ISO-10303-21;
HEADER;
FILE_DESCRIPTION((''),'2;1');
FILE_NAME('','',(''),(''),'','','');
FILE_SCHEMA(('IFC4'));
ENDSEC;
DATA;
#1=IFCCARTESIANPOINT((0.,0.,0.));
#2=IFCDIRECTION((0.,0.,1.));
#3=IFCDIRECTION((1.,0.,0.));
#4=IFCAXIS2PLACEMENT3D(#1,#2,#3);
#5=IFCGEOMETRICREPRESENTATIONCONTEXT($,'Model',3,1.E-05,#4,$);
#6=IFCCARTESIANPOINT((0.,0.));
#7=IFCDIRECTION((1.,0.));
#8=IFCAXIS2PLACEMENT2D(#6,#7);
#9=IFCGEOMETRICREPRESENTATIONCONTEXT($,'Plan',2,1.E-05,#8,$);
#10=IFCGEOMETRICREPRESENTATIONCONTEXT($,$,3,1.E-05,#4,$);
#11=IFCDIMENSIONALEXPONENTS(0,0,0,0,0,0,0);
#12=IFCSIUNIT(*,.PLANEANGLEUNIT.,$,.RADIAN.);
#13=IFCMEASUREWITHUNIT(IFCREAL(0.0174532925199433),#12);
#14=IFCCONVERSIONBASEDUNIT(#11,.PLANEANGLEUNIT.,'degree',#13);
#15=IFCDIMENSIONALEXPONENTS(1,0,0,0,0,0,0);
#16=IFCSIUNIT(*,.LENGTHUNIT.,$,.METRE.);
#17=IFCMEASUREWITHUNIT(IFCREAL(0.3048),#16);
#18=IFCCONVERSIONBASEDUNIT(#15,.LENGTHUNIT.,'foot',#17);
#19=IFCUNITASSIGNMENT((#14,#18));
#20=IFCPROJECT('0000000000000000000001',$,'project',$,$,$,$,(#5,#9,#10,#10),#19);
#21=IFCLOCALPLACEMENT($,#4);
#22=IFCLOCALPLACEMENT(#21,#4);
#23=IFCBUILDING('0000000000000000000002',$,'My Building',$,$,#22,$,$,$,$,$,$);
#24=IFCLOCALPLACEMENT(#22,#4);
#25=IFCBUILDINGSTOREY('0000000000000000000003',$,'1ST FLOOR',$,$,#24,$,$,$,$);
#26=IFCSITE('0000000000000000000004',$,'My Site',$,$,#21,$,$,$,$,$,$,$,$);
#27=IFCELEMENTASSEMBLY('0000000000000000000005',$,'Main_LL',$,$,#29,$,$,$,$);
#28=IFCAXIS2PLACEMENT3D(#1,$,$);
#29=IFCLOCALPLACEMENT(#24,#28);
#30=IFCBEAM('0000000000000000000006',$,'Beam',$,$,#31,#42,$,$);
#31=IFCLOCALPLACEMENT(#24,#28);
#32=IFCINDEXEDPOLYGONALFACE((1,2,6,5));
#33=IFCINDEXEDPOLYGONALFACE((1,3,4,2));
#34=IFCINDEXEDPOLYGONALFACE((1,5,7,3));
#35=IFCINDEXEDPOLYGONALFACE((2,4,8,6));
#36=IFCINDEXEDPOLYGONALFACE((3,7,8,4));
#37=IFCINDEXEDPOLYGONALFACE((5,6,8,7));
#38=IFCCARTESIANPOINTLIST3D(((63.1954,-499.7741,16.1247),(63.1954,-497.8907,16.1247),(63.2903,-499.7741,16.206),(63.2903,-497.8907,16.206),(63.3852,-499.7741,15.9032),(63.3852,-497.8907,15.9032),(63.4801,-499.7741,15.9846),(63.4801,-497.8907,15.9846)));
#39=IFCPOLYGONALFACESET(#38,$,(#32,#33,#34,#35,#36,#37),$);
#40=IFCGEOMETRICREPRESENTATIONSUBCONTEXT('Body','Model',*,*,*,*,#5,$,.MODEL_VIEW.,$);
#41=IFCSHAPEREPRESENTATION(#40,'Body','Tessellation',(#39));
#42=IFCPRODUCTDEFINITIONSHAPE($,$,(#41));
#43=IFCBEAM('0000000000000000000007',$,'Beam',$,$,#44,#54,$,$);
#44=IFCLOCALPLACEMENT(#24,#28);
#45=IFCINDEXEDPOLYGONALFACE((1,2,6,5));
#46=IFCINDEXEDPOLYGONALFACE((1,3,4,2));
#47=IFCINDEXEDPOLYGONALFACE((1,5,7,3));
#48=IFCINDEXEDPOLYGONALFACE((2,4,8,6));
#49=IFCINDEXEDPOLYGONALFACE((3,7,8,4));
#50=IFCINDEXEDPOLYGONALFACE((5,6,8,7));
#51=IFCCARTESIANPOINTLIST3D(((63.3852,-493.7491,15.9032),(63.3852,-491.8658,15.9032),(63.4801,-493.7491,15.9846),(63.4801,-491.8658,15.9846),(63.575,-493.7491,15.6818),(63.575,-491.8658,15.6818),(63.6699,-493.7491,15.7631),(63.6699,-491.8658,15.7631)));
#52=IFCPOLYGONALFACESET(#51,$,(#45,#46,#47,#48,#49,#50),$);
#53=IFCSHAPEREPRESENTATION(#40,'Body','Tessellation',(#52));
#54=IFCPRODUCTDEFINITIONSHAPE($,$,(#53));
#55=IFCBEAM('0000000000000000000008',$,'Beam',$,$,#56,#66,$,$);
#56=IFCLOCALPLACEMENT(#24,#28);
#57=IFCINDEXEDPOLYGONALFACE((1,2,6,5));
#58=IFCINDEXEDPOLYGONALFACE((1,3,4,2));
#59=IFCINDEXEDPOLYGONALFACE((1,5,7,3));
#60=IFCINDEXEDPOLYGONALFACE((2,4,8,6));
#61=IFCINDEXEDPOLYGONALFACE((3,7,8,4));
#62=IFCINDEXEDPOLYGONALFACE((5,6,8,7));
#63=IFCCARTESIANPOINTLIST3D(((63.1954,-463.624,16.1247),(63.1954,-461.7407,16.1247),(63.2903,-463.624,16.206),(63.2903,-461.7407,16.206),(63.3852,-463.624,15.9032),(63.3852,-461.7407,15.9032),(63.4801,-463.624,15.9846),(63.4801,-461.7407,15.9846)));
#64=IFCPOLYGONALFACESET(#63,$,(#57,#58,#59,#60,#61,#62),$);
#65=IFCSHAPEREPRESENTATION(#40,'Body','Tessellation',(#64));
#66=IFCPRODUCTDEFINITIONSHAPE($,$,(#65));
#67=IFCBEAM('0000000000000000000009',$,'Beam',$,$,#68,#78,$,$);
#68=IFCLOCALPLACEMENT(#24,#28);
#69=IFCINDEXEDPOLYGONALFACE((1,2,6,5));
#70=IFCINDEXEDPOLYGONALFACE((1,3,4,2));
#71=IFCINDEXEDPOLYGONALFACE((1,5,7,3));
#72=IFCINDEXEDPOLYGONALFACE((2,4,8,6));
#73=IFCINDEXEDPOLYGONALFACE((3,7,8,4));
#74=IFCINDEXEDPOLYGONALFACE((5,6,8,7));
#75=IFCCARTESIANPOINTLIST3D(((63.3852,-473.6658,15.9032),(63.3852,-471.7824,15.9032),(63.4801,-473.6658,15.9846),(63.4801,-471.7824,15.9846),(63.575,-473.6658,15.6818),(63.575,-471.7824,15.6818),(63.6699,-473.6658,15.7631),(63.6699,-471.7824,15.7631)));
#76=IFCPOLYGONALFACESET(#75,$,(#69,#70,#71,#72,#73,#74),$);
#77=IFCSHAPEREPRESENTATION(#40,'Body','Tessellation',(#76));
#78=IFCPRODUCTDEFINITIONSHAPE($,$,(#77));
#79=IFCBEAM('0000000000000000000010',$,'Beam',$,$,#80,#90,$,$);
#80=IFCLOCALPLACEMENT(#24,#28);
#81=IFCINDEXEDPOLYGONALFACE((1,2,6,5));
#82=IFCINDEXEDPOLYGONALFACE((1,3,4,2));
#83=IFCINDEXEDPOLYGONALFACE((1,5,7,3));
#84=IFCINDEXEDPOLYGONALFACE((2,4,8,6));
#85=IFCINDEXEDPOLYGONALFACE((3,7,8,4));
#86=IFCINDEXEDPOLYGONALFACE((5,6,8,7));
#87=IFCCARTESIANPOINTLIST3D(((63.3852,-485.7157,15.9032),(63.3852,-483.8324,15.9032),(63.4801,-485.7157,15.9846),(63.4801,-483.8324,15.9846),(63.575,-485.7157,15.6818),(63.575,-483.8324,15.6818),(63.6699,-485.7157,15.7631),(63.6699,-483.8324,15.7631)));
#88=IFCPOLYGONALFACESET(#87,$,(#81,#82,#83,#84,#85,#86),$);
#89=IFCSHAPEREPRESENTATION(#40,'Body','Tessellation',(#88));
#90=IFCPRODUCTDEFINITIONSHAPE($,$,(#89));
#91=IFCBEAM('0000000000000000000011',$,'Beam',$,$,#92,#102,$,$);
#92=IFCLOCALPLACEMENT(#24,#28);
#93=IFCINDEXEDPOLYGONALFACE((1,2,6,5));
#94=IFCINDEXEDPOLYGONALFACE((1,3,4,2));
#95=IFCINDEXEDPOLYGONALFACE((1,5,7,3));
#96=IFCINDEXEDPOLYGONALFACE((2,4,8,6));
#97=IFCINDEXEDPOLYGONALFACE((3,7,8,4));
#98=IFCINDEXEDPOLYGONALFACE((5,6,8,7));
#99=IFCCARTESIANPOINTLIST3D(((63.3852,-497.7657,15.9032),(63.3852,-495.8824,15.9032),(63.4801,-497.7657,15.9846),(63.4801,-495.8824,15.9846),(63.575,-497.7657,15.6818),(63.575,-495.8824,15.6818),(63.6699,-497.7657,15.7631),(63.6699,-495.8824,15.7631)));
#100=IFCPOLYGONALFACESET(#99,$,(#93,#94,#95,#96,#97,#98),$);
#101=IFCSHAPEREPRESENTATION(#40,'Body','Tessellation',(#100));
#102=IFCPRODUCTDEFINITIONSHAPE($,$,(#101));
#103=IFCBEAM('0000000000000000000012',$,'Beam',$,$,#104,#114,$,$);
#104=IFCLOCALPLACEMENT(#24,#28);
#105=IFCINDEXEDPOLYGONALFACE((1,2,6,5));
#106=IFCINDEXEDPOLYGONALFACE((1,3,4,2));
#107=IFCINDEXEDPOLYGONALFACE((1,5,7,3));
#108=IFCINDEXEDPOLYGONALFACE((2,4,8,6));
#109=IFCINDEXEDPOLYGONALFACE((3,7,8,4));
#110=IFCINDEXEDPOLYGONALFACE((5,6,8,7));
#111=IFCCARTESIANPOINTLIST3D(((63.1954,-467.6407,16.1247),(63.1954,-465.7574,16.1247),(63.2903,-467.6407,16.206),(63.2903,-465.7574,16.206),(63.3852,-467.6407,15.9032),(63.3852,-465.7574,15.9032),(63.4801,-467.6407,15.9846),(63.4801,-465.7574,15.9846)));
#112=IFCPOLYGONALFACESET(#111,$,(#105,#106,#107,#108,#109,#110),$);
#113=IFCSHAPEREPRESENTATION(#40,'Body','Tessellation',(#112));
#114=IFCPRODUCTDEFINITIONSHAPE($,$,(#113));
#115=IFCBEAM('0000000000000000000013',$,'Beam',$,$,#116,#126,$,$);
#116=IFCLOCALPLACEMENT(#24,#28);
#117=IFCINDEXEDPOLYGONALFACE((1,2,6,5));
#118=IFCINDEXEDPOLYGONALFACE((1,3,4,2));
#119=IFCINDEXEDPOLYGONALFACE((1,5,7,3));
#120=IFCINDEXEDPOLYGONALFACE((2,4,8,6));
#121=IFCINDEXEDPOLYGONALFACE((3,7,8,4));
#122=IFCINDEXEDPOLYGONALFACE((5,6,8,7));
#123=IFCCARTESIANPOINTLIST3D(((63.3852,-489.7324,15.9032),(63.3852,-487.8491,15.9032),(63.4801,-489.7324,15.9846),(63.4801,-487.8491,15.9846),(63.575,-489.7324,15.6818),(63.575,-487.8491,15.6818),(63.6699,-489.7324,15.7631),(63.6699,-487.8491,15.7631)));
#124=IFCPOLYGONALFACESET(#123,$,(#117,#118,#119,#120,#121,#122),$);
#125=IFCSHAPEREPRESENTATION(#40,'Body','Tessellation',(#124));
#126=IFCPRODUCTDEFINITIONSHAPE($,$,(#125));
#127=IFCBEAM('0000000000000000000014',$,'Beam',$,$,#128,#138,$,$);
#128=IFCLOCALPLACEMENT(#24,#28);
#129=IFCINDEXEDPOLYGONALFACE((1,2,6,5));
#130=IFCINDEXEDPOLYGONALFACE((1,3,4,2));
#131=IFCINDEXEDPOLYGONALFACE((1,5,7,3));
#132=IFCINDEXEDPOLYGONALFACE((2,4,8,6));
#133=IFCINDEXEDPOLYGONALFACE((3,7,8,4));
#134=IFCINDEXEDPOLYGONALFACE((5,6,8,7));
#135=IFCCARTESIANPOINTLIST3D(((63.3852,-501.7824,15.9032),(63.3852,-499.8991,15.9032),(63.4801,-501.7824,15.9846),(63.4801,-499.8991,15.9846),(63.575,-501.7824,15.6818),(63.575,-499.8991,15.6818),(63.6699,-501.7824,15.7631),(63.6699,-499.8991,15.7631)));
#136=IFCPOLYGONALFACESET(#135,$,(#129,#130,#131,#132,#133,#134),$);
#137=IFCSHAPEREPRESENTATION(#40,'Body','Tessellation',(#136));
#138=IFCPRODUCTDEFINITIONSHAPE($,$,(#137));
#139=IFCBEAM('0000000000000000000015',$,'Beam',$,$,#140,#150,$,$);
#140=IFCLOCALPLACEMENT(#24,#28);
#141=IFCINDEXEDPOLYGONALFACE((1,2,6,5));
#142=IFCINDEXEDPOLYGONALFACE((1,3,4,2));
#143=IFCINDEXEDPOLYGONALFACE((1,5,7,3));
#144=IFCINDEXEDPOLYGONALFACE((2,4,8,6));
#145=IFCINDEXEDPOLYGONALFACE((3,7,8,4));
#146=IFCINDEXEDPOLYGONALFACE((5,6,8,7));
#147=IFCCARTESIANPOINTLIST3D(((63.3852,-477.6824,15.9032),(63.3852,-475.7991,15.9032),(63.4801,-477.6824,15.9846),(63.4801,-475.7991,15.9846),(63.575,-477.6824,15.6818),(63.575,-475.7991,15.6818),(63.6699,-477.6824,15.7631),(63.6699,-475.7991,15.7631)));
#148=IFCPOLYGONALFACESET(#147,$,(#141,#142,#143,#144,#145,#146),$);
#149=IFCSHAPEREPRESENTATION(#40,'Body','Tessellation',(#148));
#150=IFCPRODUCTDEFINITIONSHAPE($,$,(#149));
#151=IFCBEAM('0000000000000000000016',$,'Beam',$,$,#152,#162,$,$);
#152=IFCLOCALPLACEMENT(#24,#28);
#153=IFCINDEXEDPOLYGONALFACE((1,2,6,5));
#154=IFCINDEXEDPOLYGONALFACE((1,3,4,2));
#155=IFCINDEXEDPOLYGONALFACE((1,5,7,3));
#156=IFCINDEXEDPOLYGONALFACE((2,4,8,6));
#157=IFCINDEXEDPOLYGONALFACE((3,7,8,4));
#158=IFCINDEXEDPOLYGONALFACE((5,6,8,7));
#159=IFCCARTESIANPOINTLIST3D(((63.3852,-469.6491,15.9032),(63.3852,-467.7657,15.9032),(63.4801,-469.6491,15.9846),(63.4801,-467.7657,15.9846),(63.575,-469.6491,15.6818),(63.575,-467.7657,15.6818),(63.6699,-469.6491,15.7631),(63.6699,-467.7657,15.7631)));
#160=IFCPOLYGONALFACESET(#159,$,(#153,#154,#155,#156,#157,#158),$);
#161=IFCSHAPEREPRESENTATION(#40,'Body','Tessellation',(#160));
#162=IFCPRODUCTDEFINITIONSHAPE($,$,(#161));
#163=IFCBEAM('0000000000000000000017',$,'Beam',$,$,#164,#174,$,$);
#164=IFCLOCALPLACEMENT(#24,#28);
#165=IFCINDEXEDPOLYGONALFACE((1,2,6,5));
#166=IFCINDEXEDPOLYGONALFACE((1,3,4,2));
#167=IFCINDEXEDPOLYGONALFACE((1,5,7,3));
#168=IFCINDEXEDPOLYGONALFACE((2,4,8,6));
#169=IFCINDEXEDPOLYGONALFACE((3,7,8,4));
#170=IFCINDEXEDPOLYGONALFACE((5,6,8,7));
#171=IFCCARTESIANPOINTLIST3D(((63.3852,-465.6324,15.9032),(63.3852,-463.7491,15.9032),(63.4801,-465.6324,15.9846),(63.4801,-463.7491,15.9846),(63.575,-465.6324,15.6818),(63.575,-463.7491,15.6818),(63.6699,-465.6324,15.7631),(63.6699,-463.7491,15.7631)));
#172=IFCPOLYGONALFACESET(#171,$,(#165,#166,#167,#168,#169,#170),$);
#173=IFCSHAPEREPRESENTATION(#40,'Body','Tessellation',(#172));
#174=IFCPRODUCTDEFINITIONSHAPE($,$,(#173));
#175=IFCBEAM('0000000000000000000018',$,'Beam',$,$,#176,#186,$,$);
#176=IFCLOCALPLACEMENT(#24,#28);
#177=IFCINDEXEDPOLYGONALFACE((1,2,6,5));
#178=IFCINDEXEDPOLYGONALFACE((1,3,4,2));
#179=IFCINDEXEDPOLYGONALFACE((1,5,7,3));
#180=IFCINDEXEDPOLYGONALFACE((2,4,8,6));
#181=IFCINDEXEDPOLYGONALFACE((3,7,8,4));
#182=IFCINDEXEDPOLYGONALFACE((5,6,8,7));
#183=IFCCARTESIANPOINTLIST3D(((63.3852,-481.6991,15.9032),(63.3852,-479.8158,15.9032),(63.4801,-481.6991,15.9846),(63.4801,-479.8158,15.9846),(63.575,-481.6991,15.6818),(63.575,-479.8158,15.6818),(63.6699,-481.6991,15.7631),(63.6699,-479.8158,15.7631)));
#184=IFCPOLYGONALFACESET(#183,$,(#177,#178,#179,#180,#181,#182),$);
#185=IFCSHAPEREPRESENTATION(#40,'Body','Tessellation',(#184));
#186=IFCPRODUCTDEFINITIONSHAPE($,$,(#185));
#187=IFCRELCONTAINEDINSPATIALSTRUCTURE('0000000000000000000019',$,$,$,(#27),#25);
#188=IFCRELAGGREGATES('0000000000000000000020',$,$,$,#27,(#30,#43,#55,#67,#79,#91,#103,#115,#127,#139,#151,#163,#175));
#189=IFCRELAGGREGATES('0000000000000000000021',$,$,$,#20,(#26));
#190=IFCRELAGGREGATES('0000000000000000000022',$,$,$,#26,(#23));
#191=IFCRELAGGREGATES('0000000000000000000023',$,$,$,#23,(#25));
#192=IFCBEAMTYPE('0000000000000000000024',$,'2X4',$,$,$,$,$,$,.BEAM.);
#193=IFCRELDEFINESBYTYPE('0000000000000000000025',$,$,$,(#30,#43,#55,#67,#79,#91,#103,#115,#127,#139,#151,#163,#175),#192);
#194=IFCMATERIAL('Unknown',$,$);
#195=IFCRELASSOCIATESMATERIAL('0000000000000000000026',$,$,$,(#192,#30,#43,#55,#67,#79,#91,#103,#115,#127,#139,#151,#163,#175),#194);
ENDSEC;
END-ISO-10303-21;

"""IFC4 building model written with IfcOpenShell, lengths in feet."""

from ifc_helpers import new_model, entity, si_unit, converted_unit, frame, origin_with_axes, origin_2d_with_axis, place, context, subcontext, project, spatial, rectangle, extrude, material, material_profile, profile_set, profile_usage, type_object, element, aggregate, save


model = new_model("IFC4")

# Units and contexts
model_context = context("Model", 3, precision=1e-05, world=origin_with_axes())
plan_context = context("Plan", 2, precision=1e-05, world=origin_2d_with_axis())
context_of_model = context(None, 3, precision=1e-05, world=origin_with_axes())
body_context = subcontext(model_context, "Body", "Model", "MODEL_VIEW")
ifc_project = project(units=[converted_unit("PLANEANGLEUNIT", "degree", entity("IfcReal", 0.0174532925199433), si_unit("PLANEANGLEUNIT", "RADIAN"), dimensions=[0, 0, 0, 0, 0, 0, 0]), converted_unit("LENGTHUNIT", "foot", entity("IfcReal", 0.3048), si_unit("LENGTHUNIT", "METRE"), dimensions=[1, 0, 0, 0, 0, 0, 0])], contexts=[model_context, plan_context, context_of_model, context_of_model])

# Site, building, storey
site_placement = place(None, origin_with_axes())
site = spatial("IfcSite", under=ifc_project, at=site_placement, Name="My Site")
building_placement = place(site_placement, origin_with_axes())
building = spatial("IfcBuilding", under=site, at=building_placement, Name="My Building")
storey_placement = place(building_placement, origin_with_axes())
storey = spatial("IfcBuildingStorey", under=building, at=storey_placement, Name="1ST FLOOR")

# Element assembly, beams
assembly_placement = place(storey_placement, origin_with_axes())
assembly = element("IfcElementAssembly", 1, at=assembly_placement, inside=storey, Name="Main_LL")
ifc_material_1 = material(Name="Unknown")
ifc_material_profile_1 = material_profile(ifc_material_1, rectangle(XDim=0.125, YDim=0.2917))
ifc_profile_set_1 = profile_set([ifc_material_profile_1])
ifc_profile_usage_1 = profile_usage(ifc_profile_set_1, cardinal=5)
beam_type_1 = type_object("IfcBeamType", Name="2X4", PredefinedType="BEAM", material=ifc_profile_set_1)
beam_1_placement = place(assembly_placement, frame((63.3378, -497.8907, 16.0546), z_axis=(0.0, -1.0, 0.0), x_axis=(-0.759271, 0.0, -0.650774)))
beam_1 = element("IfcBeam", 2, at=beam_1_placement, type_object=beam_type_1, material=ifc_profile_usage_1, Name="Beam", context=body_context, shape_type="SweptSolid", body=[
    extrude(rectangle(XDim=0.125, YDim=0.2917), origin_with_axes(), (0.0, 0.0, 1.0), 1.8833),
])
ifc_profile_usage_2 = profile_usage(ifc_profile_set_1, cardinal=5)
beam_2_placement = place(assembly_placement, frame((63.5276, -491.8658, 15.8332), z_axis=(0.0, -1.0, 0.0), x_axis=(-0.759271, 0.0, -0.650774)))
beam_2 = element("IfcBeam", 3, at=beam_2_placement, type_object=beam_type_1, material=ifc_profile_usage_2, Name="Beam", context=body_context, shape_type="SweptSolid", body=[
    extrude(rectangle(XDim=0.125, YDim=0.2917), origin_with_axes(), (0.0, 0.0, 1.0), 1.8833),
])
ifc_profile_usage_3 = profile_usage(ifc_profile_set_1, cardinal=5)
beam_3_placement = place(assembly_placement, frame((63.3378, -461.7407, 16.0546), z_axis=(0.0, -1.0, 0.0), x_axis=(-0.759271, 0.0, -0.650774)))
beam_3 = element("IfcBeam", 4, at=beam_3_placement, type_object=beam_type_1, material=ifc_profile_usage_3, Name="Beam", context=body_context, shape_type="SweptSolid", body=[
    extrude(rectangle(XDim=0.125, YDim=0.2917), origin_with_axes(), (0.0, 0.0, 1.0), 1.8833),
])
ifc_profile_usage_4 = profile_usage(ifc_profile_set_1, cardinal=5)
beam_4_placement = place(assembly_placement, frame((63.5276, -471.7824, 15.8332), z_axis=(0.0, -1.0, 0.0), x_axis=(-0.759271, 0.0, -0.650774)))
beam_4 = element("IfcBeam", 5, at=beam_4_placement, type_object=beam_type_1, material=ifc_profile_usage_4, Name="Beam", context=body_context, shape_type="SweptSolid", body=[
    extrude(rectangle(XDim=0.125, YDim=0.2917), origin_with_axes(), (0.0, 0.0, 1.0), 1.8833),
])
ifc_profile_usage_5 = profile_usage(ifc_profile_set_1, cardinal=5)
beam_5_placement = place(assembly_placement, frame((63.5276, -483.8324, 15.8332), z_axis=(0.0, -1.0, 0.0), x_axis=(-0.759271, 0.0, -0.650774)))
beam_5 = element("IfcBeam", 6, at=beam_5_placement, type_object=beam_type_1, material=ifc_profile_usage_5, Name="Beam", context=body_context, shape_type="SweptSolid", body=[
    extrude(rectangle(XDim=0.125, YDim=0.2917), origin_with_axes(), (0.0, 0.0, 1.0), 1.8833),
])
ifc_profile_usage_6 = profile_usage(ifc_profile_set_1, cardinal=5)
beam_6_placement = place(assembly_placement, frame((63.5276, -495.8824, 15.8332), z_axis=(0.0, -1.0, 0.0), x_axis=(-0.759271, 0.0, -0.650774)))
beam_6 = element("IfcBeam", 7, at=beam_6_placement, type_object=beam_type_1, material=ifc_profile_usage_6, Name="Beam", context=body_context, shape_type="SweptSolid", body=[
    extrude(rectangle(XDim=0.125, YDim=0.2917), origin_with_axes(), (0.0, 0.0, 1.0), 1.8833),
])
ifc_profile_usage_7 = profile_usage(ifc_profile_set_1, cardinal=5)
beam_7_placement = place(assembly_placement, frame((63.3378, -465.7574, 16.0546), z_axis=(0.0, -1.0, 0.0), x_axis=(-0.759271, 0.0, -0.650774)))
beam_7 = element("IfcBeam", 8, at=beam_7_placement, type_object=beam_type_1, material=ifc_profile_usage_7, Name="Beam", context=body_context, shape_type="SweptSolid", body=[
    extrude(rectangle(XDim=0.125, YDim=0.2917), origin_with_axes(), (0.0, 0.0, 1.0), 1.8833),
])
ifc_profile_usage_8 = profile_usage(ifc_profile_set_1, cardinal=5)
beam_8_placement = place(assembly_placement, frame((63.5276, -487.8491, 15.8332), z_axis=(0.0, -1.0, 0.0), x_axis=(-0.759271, 0.0, -0.650774)))
beam_8 = element("IfcBeam", 9, at=beam_8_placement, type_object=beam_type_1, material=ifc_profile_usage_8, Name="Beam", context=body_context, shape_type="SweptSolid", body=[
    extrude(rectangle(XDim=0.125, YDim=0.2917), origin_with_axes(), (0.0, 0.0, 1.0), 1.8833),
])
ifc_profile_usage_9 = profile_usage(ifc_profile_set_1, cardinal=5)
beam_9_placement = place(assembly_placement, frame((63.5276, -499.8991, 15.8332), z_axis=(0.0, -1.0, 0.0), x_axis=(-0.759271, 0.0, -0.650774)))
beam_9 = element("IfcBeam", 10, at=beam_9_placement, type_object=beam_type_1, material=ifc_profile_usage_9, Name="Beam", context=body_context, shape_type="SweptSolid", body=[
    extrude(rectangle(XDim=0.125, YDim=0.2917), origin_with_axes(), (0.0, 0.0, 1.0), 1.8833),
])
ifc_profile_usage_10 = profile_usage(ifc_profile_set_1, cardinal=5)
beam_10_placement = place(assembly_placement, frame((63.5276, -475.7991, 15.8332), z_axis=(0.0, -1.0, 0.0), x_axis=(-0.759271, 0.0, -0.650774)))
beam_10 = element("IfcBeam", 11, at=beam_10_placement, type_object=beam_type_1, material=ifc_profile_usage_10, Name="Beam", context=body_context, shape_type="SweptSolid", body=[
    extrude(rectangle(XDim=0.125, YDim=0.2917), origin_with_axes(), (0.0, 0.0, 1.0), 1.8833),
])
ifc_profile_usage_11 = profile_usage(ifc_profile_set_1, cardinal=5)
beam_11_placement = place(assembly_placement, frame((63.5276, -467.7657, 15.8332), z_axis=(0.0, -1.0, 0.0), x_axis=(-0.759271, 0.0, -0.650774)))
beam_11 = element("IfcBeam", 12, at=beam_11_placement, type_object=beam_type_1, material=ifc_profile_usage_11, Name="Beam", context=body_context, shape_type="SweptSolid", body=[
    extrude(rectangle(XDim=0.125, YDim=0.2917), origin_with_axes(), (0.0, 0.0, 1.0), 1.8833),
])
ifc_profile_usage_12 = profile_usage(ifc_profile_set_1, cardinal=5)
beam_12_placement = place(assembly_placement, frame((63.5276, -463.7491, 15.8332), z_axis=(0.0, -1.0, 0.0), x_axis=(-0.759271, 0.0, -0.650774)))
beam_12 = element("IfcBeam", 13, at=beam_12_placement, type_object=beam_type_1, material=ifc_profile_usage_12, Name="Beam", context=body_context, shape_type="SweptSolid", body=[
    extrude(rectangle(XDim=0.125, YDim=0.2917), origin_with_axes(), (0.0, 0.0, 1.0), 1.8833),
])
ifc_profile_usage_13 = profile_usage(ifc_profile_set_1, cardinal=5)
beam_13_placement = place(assembly_placement, frame((63.5276, -479.8158, 15.8332), z_axis=(0.0, -1.0, 0.0), x_axis=(-0.759271, 0.0, -0.650774)))
beam_13 = element("IfcBeam", 14, at=beam_13_placement, type_object=beam_type_1, material=ifc_profile_usage_13, Name="Beam", context=body_context, shape_type="SweptSolid", body=[
    extrude(rectangle(XDim=0.125, YDim=0.2917), origin_with_axes(), (0.0, 0.0, 1.0), 1.8833),
])
aggregate(assembly, [beam_1, beam_2, beam_3, beam_4, beam_5, beam_6, beam_7, beam_8, beam_9, beam_10, beam_11, beam_12, beam_13])

save(model, "model.ifc")
